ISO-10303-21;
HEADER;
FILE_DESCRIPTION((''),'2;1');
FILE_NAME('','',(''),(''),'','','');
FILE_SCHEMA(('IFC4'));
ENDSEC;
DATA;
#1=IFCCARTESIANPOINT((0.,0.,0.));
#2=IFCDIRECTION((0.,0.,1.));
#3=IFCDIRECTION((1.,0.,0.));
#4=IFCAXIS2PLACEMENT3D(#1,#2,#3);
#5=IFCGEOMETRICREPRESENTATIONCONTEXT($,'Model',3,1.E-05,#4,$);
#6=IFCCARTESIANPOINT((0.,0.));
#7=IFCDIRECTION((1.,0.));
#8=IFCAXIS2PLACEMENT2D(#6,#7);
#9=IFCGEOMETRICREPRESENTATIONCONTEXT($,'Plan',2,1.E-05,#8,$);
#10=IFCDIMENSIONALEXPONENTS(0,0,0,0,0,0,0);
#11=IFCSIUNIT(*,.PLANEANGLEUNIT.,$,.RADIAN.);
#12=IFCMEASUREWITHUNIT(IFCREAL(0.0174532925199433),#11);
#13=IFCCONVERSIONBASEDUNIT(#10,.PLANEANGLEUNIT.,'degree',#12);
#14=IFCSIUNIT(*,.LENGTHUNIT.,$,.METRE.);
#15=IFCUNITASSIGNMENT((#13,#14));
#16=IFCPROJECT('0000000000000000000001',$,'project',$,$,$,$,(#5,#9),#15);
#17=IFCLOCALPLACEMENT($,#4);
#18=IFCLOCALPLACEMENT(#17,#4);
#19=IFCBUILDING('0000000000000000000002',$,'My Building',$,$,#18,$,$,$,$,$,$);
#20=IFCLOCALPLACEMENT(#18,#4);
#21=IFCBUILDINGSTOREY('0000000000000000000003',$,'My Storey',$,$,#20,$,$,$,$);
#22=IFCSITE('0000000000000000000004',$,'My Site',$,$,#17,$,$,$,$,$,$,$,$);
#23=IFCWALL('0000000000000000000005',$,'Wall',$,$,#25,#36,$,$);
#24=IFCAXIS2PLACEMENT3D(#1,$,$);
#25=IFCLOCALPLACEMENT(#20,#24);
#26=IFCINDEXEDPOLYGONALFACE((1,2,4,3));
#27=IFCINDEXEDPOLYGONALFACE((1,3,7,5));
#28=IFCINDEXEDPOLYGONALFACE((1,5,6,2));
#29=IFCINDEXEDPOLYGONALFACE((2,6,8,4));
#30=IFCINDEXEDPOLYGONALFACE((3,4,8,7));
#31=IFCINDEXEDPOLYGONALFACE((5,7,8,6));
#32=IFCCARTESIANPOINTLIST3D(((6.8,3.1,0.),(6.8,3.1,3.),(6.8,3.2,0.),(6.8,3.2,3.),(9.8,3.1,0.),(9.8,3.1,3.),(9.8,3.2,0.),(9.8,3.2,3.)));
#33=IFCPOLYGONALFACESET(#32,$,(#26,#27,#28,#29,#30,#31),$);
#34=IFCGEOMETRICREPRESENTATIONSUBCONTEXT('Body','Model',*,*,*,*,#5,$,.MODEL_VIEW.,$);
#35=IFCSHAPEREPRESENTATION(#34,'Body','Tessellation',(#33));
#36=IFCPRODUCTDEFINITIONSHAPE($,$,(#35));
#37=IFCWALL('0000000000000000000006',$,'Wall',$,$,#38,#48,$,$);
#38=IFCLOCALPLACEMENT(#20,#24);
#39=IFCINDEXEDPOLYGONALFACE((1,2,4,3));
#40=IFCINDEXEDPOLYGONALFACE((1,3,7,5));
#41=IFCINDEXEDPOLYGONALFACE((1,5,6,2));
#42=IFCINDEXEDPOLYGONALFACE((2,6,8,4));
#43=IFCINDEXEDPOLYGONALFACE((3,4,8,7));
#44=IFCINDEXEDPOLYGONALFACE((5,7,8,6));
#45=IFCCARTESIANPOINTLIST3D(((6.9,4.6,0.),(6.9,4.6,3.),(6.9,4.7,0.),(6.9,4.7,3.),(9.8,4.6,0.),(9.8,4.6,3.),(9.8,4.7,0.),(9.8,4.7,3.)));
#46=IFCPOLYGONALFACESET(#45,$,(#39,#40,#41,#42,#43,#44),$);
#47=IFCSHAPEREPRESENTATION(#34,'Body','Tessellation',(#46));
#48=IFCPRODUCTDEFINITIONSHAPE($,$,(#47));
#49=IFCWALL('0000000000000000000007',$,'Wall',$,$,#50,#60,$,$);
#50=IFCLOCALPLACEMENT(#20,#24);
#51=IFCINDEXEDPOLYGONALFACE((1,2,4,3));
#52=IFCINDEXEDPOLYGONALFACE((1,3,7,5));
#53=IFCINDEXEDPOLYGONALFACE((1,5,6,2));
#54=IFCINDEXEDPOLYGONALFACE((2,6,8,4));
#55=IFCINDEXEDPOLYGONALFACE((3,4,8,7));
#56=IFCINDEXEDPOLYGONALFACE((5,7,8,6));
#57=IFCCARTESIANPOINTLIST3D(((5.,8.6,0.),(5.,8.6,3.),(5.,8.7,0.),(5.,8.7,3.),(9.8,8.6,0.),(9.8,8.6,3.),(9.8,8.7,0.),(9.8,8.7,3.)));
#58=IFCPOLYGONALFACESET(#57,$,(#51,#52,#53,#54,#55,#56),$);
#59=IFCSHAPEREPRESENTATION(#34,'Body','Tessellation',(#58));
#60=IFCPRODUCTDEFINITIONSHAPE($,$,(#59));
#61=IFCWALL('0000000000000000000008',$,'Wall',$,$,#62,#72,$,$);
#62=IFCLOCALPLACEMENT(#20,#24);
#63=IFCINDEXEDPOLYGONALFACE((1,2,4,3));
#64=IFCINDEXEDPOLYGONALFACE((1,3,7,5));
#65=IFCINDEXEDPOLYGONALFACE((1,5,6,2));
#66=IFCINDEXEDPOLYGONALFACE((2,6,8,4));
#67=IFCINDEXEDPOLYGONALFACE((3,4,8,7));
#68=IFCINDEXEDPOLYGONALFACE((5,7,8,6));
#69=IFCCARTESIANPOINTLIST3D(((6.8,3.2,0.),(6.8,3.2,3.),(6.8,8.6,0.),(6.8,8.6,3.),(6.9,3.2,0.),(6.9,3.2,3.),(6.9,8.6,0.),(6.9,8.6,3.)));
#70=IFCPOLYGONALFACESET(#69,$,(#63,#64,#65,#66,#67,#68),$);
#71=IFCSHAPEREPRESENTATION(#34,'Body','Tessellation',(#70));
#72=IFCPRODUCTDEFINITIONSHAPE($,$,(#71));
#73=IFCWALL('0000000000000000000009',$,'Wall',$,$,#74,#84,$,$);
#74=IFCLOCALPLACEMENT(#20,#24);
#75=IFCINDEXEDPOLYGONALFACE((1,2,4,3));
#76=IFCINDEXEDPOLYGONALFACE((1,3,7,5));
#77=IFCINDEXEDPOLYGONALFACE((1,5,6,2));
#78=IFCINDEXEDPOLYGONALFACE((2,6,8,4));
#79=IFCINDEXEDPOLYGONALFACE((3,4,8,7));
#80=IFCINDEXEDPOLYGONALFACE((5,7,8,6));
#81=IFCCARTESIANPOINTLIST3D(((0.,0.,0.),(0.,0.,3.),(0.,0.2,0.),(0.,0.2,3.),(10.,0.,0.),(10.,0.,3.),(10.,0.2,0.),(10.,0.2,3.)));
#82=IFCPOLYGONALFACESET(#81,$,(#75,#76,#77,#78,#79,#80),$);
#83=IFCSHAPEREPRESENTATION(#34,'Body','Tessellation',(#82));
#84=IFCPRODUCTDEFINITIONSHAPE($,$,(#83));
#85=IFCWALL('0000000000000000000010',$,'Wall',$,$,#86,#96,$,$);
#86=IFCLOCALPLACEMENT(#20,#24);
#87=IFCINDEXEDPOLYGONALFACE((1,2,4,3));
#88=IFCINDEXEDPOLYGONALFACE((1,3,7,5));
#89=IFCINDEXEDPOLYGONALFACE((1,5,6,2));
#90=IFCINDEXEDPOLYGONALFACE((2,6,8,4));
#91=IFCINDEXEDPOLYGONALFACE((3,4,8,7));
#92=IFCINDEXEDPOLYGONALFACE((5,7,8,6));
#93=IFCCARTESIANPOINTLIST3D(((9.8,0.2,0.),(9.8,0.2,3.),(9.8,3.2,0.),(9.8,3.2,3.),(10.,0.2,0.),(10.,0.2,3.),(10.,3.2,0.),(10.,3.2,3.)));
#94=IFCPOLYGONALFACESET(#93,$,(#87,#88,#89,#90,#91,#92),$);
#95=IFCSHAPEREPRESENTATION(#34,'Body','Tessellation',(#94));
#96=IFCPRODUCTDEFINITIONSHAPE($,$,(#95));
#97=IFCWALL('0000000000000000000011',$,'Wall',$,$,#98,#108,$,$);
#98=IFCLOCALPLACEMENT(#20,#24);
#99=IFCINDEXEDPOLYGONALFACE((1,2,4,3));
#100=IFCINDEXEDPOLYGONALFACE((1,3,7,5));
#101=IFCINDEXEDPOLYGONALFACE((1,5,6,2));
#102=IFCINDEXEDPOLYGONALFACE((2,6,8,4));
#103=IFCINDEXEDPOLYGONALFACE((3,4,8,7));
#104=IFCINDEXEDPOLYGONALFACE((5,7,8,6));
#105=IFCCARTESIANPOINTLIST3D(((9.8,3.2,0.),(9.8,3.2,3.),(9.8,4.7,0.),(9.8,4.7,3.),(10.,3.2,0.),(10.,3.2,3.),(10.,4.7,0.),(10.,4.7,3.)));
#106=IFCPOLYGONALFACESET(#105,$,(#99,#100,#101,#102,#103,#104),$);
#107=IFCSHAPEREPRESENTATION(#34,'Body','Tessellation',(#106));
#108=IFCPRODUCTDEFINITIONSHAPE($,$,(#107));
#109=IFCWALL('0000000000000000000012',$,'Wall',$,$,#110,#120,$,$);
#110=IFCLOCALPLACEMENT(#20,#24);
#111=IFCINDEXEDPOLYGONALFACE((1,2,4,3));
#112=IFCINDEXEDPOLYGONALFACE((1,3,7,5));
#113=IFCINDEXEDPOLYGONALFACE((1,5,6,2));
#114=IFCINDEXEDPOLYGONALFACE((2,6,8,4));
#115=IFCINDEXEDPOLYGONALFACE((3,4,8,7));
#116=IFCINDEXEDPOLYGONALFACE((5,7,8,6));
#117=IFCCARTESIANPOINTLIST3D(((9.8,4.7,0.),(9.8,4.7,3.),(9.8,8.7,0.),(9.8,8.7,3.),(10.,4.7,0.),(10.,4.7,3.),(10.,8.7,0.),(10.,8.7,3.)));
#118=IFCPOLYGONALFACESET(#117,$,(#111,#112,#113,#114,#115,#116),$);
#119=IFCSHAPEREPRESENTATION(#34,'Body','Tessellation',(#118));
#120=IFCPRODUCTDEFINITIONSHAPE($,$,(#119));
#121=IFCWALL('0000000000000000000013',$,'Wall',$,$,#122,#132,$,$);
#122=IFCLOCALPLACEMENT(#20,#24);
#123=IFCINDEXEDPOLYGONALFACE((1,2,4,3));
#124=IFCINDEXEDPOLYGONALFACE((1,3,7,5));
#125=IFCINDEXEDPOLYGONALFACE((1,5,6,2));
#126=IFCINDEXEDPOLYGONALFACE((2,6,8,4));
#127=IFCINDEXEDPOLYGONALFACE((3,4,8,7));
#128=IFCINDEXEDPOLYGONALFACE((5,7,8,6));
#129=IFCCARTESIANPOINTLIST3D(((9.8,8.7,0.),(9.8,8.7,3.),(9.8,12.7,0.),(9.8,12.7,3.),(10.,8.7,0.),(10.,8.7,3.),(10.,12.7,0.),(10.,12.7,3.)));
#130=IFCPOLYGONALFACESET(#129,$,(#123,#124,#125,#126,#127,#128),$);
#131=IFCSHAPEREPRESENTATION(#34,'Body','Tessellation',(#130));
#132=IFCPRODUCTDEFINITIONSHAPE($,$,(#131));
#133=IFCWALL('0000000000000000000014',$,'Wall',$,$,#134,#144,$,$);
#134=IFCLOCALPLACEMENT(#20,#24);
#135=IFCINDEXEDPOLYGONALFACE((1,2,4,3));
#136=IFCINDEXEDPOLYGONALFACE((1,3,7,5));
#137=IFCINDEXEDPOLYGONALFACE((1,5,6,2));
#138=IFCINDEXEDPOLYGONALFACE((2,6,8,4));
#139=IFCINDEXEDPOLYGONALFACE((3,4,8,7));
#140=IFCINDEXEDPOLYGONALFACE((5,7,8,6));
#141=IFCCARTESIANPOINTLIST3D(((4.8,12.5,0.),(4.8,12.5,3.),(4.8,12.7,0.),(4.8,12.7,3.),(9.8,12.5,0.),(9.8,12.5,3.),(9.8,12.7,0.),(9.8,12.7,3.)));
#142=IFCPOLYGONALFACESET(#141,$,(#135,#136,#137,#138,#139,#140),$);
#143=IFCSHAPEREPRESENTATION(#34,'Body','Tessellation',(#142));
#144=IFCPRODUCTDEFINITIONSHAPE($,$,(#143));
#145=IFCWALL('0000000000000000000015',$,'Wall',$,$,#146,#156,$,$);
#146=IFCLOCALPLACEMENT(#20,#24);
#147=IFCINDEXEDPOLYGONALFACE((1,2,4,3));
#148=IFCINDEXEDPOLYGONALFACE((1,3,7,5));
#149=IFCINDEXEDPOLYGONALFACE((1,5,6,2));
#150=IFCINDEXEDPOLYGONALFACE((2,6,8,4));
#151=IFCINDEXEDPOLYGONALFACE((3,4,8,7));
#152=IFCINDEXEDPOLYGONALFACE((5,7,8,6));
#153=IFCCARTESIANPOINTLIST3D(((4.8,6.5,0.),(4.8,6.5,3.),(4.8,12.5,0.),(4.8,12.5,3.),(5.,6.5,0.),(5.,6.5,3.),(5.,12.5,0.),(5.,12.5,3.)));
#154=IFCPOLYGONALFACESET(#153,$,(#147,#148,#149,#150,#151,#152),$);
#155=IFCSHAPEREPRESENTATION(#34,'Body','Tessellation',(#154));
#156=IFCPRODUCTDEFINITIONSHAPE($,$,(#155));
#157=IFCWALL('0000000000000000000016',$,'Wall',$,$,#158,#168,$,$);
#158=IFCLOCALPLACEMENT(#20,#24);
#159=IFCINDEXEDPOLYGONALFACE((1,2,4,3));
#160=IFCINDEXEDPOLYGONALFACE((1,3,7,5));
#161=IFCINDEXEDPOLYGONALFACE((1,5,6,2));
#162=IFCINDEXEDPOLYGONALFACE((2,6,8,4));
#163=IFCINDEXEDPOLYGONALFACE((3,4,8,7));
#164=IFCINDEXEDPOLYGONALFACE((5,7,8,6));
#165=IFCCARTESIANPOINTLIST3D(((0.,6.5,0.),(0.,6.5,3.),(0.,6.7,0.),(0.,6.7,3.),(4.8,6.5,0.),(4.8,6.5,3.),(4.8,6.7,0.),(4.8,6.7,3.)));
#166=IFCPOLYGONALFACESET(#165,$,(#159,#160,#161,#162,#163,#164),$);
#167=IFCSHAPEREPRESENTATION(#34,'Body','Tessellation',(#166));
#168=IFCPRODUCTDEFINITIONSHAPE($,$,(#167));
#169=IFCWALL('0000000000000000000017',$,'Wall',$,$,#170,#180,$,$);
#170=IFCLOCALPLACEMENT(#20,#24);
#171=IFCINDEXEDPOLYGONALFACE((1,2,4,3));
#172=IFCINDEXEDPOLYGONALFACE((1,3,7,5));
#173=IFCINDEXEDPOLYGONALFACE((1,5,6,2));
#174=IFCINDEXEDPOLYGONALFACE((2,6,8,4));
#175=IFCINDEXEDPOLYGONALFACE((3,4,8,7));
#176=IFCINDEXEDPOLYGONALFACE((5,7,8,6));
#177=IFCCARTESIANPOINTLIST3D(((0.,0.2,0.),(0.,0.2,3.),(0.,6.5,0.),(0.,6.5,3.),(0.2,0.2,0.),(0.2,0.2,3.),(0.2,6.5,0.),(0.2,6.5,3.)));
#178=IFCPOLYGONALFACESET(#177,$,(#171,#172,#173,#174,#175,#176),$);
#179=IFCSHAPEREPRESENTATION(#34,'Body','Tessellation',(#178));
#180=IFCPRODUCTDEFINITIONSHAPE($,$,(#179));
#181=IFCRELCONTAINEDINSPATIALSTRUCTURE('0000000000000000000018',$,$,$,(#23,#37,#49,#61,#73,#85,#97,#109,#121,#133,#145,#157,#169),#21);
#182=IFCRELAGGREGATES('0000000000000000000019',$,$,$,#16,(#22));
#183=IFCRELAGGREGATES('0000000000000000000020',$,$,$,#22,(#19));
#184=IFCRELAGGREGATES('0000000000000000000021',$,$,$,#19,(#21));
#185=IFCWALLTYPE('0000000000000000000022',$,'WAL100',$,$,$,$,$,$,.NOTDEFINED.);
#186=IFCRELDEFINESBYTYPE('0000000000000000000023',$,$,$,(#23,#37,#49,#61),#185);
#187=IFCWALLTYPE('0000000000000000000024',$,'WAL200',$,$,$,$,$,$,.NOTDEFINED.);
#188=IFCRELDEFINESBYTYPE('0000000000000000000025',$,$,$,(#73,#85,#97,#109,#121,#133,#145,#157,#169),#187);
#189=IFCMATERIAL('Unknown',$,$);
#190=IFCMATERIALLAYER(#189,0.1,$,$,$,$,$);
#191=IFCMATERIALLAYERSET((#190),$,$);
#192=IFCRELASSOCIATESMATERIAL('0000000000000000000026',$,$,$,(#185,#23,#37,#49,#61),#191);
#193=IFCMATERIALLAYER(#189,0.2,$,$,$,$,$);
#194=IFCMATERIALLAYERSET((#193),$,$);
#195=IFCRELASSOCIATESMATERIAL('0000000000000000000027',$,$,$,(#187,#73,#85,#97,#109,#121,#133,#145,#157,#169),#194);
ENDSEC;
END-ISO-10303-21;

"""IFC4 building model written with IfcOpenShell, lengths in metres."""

from ifc_helpers import new_model, entity, si_unit, converted_unit, frame, origin_with_axes, origin_2d_with_axis, place, context, subcontext, project, spatial, indexed_curve, outline, extrude, material, layer, layer_set, layer_usage, type_object, element, save


model = new_model("IFC4")

# Units and contexts
model_context = context("Model", 3, precision=1e-05, world=origin_with_axes())
plan_context = context("Plan", 2, precision=1e-05, world=origin_2d_with_axis())
body_context = subcontext(model_context, "Body", "Model", "MODEL_VIEW")
ifc_project = project(units=[converted_unit("PLANEANGLEUNIT", "degree", entity("IfcReal", 0.0174532925199433), si_unit("PLANEANGLEUNIT", "RADIAN"), dimensions=[0, 0, 0, 0, 0, 0, 0]), si_unit("LENGTHUNIT", "METRE")], contexts=[model_context, plan_context])

# Site, building, storey
site_placement = place(None, origin_with_axes())
site = spatial("IfcSite", under=ifc_project, at=site_placement, Name="My Site")
building_placement = place(site_placement, origin_with_axes())
building = spatial("IfcBuilding", under=site, at=building_placement, Name="My Building")
storey_placement = place(building_placement, origin_with_axes())
storey = spatial("IfcBuildingStorey", under=building, at=storey_placement, Name="My Storey")

# Walls
ifc_material = material(Name="Unknown")
ifc_layer_1 = layer(ifc_material, 0.1)
ifc_layer_set_1 = layer_set([ifc_layer_1])
ifc_layer_usage_1 = layer_usage(ifc_layer_set_1, "AXIS2", "POSITIVE", 0.0)
wall_type_1 = type_object("IfcWallType", Name="WAL100", PredefinedType="NOTDEFINED", material=ifc_layer_set_1)
wall_1_placement = place(storey_placement, frame((9.8, 3.2, 0.0), z_axis=(0.0, 0.0, 1.0), x_axis=(-1.0, 0.0, 0.0)))
element("IfcWall", 1, at=wall_1_placement, inside=storey, type_object=wall_type_1, material=ifc_layer_usage_1, Name="Wall", context=body_context, shape_type="SweptSolid", body=[
    extrude(outline(indexed_curve([(0.0, 0.0), (0.0, 0.1), (3.0, 0.1), (3.0, 0.0), (0.0, 0.0)], self_intersect=False)), origin_with_axes(), (0.0, 0.0, 1.0), 3.0),
])
ifc_layer_usage_2 = layer_usage(ifc_layer_set_1, "AXIS2", "POSITIVE", 0.0)
wall_2_placement = place(storey_placement, frame((9.8, 4.7, 0.0), z_axis=(0.0, 0.0, 1.0), x_axis=(-1.0, 0.0, 0.0)))
element("IfcWall", 2, at=wall_2_placement, inside=storey, type_object=wall_type_1, material=ifc_layer_usage_2, Name="Wall", context=body_context, shape_type="SweptSolid", body=[
    extrude(outline(indexed_curve([(0.0, 0.0), (0.0, 0.1), (2.9, 0.1), (2.9, 0.0), (0.0, 0.0)], self_intersect=False)), origin_with_axes(), (0.0, 0.0, 1.0), 3.0),
])
ifc_layer_usage_3 = layer_usage(ifc_layer_set_1, "AXIS2", "POSITIVE", 0.0)
wall_3_placement = place(storey_placement, frame((9.8, 8.7, 0.0), z_axis=(0.0, 0.0, 1.0), x_axis=(-1.0, 0.0, 0.0)))
element("IfcWall", 3, at=wall_3_placement, inside=storey, type_object=wall_type_1, material=ifc_layer_usage_3, Name="Wall", context=body_context, shape_type="SweptSolid", body=[
    extrude(outline(indexed_curve([(0.0, 0.0), (0.0, 0.1), (4.8, 0.1), (4.8, 0.0), (0.0, 0.0)], self_intersect=False)), origin_with_axes(), (0.0, 0.0, 1.0), 3.0),
])
ifc_layer_usage_4 = layer_usage(ifc_layer_set_1, "AXIS2", "POSITIVE", 0.0)
wall_4_placement = place(storey_placement, frame((6.8, 8.6, 0.0), z_axis=(0.0, 0.0, 1.0), x_axis=(-0.000001, -1.0, 0.0)))
element("IfcWall", 4, at=wall_4_placement, inside=storey, type_object=wall_type_1, material=ifc_layer_usage_4, Name="Wall", context=body_context, shape_type="SweptSolid", body=[
    extrude(outline(indexed_curve([(0.0, 0.0), (0.0, 0.1), (5.4, 0.1), (5.4, 0.0), (0.0, 0.0)], self_intersect=False)), origin_with_axes(), (0.0, 0.0, 1.0), 3.0),
])
ifc_layer_2 = layer(ifc_material, 0.2)
ifc_layer_set_2 = layer_set([ifc_layer_2])
ifc_layer_usage_5 = layer_usage(ifc_layer_set_2, "AXIS2", "POSITIVE", 0.0)
wall_type_2 = type_object("IfcWallType", Name="WAL200", PredefinedType="NOTDEFINED", material=ifc_layer_set_2)
wall_5_placement = place(storey_placement, origin_with_axes())
element("IfcWall", 5, at=wall_5_placement, inside=storey, type_object=wall_type_2, material=ifc_layer_usage_5, Name="Wall", context=body_context, shape_type="SweptSolid", body=[
    extrude(outline(indexed_curve([(0.0, 0.0), (0.0, 0.2), (10.0, 0.2), (10.0, 0.0), (0.0, 0.0)], self_intersect=False)), origin_with_axes(), (0.0, 0.0, 1.0), 3.0),
])
ifc_layer_usage_6 = layer_usage(ifc_layer_set_2, "AXIS2", "POSITIVE", 0.0)
wall_6_placement = place(storey_placement, frame((10.0, 0.2, 0.0), z_axis=(0.0, 0.0, 1.0), x_axis=(0.0, 1.0, 0.0)))
element("IfcWall", 6, at=wall_6_placement, inside=storey, type_object=wall_type_2, material=ifc_layer_usage_6, Name="Wall", context=body_context, shape_type="SweptSolid", body=[
    extrude(outline(indexed_curve([(0.0, 0.0), (0.0, 0.2), (3.0, 0.2), (3.0, 0.0), (0.0, 0.0)], self_intersect=False)), origin_with_axes(), (0.0, 0.0, 1.0), 3.0),
])
ifc_layer_usage_7 = layer_usage(ifc_layer_set_2, "AXIS2", "POSITIVE", 0.0)
wall_7_placement = place(storey_placement, frame((9.8, 4.7, 0.0), z_axis=(0.0, 0.0, 1.0), x_axis=(-0.000001, -1.0, 0.0)))
element("IfcWall", 7, at=wall_7_placement, inside=storey, type_object=wall_type_2, material=ifc_layer_usage_7, Name="Wall", context=body_context, shape_type="SweptSolid", body=[
    extrude(outline(indexed_curve([(0.0, 0.0), (0.0, 0.2), (1.5, 0.2), (1.5, 0.0), (0.0, 0.0)], self_intersect=False)), origin_with_axes(), (0.0, 0.0, 1.0), 3.0),
])
ifc_layer_usage_8 = layer_usage(ifc_layer_set_2, "AXIS2", "POSITIVE", 0.0)
wall_8_placement = place(storey_placement, frame((9.8, 8.7, 0.0), z_axis=(0.0, 0.0, 1.0), x_axis=(-0.000001, -1.0, 0.0)))
element("IfcWall", 8, at=wall_8_placement, inside=storey, type_object=wall_type_2, material=ifc_layer_usage_8, Name="Wall", context=body_context, shape_type="SweptSolid", body=[
    extrude(outline(indexed_curve([(0.0, 0.0), (0.0, 0.2), (4.0, 0.2), (4.0, 0.0), (0.0, 0.0)], self_intersect=False)), origin_with_axes(), (0.0, 0.0, 1.0), 3.0),
])
ifc_layer_usage_9 = layer_usage(ifc_layer_set_2, "AXIS2", "POSITIVE", 0.0)
wall_9_placement = place(storey_placement, frame((10.0, 8.7, 0.0), z_axis=(0.0, 0.0, 1.0), x_axis=(0.000001, 1.0, 0.0)))
element("IfcWall", 9, at=wall_9_placement, inside=storey, type_object=wall_type_2, material=ifc_layer_usage_9, Name="Wall", context=body_context, shape_type="SweptSolid", body=[
    extrude(outline(indexed_curve([(0.0, 0.0), (0.0, 0.2), (4.0, 0.2), (4.0, 0.0), (0.0, 0.0)], self_intersect=False)), origin_with_axes(), (0.0, 0.0, 1.0), 3.0),
])
ifc_layer_usage_10 = layer_usage(ifc_layer_set_2, "AXIS2", "POSITIVE", 0.0)
wall_10_placement = place(storey_placement, frame((9.8, 12.7, 0.0), z_axis=(0.0, 0.0, 1.0), x_axis=(-1.0, 0.0, 0.0)))
element("IfcWall", 10, at=wall_10_placement, inside=storey, type_object=wall_type_2, material=ifc_layer_usage_10, Name="Wall", context=body_context, shape_type="SweptSolid", body=[
    extrude(outline(indexed_curve([(0.0, 0.0), (0.0, 0.2), (5.0, 0.2), (5.0, 0.0), (0.0, 0.0)], self_intersect=False)), origin_with_axes(), (0.0, 0.0, 1.0), 3.0),
])
ifc_layer_usage_11 = layer_usage(ifc_layer_set_2, "AXIS2", "POSITIVE", 0.0)
wall_11_placement = place(storey_placement, frame((4.8, 12.5, 0.0), z_axis=(0.0, 0.0, 1.0), x_axis=(0.0, -1.0, 0.0)))
element("IfcWall", 11, at=wall_11_placement, inside=storey, type_object=wall_type_2, material=ifc_layer_usage_11, Name="Wall", context=body_context, shape_type="SweptSolid", body=[
    extrude(outline(indexed_curve([(0.0, 0.0), (0.0, 0.2), (6.0, 0.2), (6.0, 0.0), (0.0, 0.0)], self_intersect=False)), origin_with_axes(), (0.0, 0.0, 1.0), 3.0),
])
ifc_layer_usage_12 = layer_usage(ifc_layer_set_2, "AXIS2", "POSITIVE", 0.0)
wall_12_placement = place(storey_placement, frame((0.0, 6.5, 0.0), z_axis=(0.0, 0.0, 1.0), x_axis=(1.0, -0.000001, 0.0)))
element("IfcWall", 12, at=wall_12_placement, inside=storey, type_object=wall_type_2, material=ifc_layer_usage_12, Name="Wall", context=body_context, shape_type="SweptSolid", body=[
    extrude(outline(indexed_curve([(0.0, 0.0), (0.0, 0.2), (4.8, 0.2), (4.8, 0.0), (0.0, 0.0)], self_intersect=False)), origin_with_axes(), (0.0, 0.0, 1.0), 3.0),
])
ifc_layer_usage_13 = layer_usage(ifc_layer_set_2, "AXIS2", "POSITIVE", 0.0)
wall_13_placement = place(storey_placement, frame((0.0, 6.5, 0.0), z_axis=(0.0, 0.0, 1.0), x_axis=(-0.000001, -1.0, 0.0)))
element("IfcWall", 13, at=wall_13_placement, inside=storey, type_object=wall_type_2, material=ifc_layer_usage_13, Name="Wall", context=body_context, shape_type="SweptSolid", body=[
    extrude(outline(indexed_curve([(0.0, 0.0), (0.0, 0.2), (6.3, 0.2), (6.3, 0.0), (0.0, 0.0)], self_intersect=False)), origin_with_axes(), (0.0, 0.0, 1.0), 3.0),
])

save(model, "model.ifc")
